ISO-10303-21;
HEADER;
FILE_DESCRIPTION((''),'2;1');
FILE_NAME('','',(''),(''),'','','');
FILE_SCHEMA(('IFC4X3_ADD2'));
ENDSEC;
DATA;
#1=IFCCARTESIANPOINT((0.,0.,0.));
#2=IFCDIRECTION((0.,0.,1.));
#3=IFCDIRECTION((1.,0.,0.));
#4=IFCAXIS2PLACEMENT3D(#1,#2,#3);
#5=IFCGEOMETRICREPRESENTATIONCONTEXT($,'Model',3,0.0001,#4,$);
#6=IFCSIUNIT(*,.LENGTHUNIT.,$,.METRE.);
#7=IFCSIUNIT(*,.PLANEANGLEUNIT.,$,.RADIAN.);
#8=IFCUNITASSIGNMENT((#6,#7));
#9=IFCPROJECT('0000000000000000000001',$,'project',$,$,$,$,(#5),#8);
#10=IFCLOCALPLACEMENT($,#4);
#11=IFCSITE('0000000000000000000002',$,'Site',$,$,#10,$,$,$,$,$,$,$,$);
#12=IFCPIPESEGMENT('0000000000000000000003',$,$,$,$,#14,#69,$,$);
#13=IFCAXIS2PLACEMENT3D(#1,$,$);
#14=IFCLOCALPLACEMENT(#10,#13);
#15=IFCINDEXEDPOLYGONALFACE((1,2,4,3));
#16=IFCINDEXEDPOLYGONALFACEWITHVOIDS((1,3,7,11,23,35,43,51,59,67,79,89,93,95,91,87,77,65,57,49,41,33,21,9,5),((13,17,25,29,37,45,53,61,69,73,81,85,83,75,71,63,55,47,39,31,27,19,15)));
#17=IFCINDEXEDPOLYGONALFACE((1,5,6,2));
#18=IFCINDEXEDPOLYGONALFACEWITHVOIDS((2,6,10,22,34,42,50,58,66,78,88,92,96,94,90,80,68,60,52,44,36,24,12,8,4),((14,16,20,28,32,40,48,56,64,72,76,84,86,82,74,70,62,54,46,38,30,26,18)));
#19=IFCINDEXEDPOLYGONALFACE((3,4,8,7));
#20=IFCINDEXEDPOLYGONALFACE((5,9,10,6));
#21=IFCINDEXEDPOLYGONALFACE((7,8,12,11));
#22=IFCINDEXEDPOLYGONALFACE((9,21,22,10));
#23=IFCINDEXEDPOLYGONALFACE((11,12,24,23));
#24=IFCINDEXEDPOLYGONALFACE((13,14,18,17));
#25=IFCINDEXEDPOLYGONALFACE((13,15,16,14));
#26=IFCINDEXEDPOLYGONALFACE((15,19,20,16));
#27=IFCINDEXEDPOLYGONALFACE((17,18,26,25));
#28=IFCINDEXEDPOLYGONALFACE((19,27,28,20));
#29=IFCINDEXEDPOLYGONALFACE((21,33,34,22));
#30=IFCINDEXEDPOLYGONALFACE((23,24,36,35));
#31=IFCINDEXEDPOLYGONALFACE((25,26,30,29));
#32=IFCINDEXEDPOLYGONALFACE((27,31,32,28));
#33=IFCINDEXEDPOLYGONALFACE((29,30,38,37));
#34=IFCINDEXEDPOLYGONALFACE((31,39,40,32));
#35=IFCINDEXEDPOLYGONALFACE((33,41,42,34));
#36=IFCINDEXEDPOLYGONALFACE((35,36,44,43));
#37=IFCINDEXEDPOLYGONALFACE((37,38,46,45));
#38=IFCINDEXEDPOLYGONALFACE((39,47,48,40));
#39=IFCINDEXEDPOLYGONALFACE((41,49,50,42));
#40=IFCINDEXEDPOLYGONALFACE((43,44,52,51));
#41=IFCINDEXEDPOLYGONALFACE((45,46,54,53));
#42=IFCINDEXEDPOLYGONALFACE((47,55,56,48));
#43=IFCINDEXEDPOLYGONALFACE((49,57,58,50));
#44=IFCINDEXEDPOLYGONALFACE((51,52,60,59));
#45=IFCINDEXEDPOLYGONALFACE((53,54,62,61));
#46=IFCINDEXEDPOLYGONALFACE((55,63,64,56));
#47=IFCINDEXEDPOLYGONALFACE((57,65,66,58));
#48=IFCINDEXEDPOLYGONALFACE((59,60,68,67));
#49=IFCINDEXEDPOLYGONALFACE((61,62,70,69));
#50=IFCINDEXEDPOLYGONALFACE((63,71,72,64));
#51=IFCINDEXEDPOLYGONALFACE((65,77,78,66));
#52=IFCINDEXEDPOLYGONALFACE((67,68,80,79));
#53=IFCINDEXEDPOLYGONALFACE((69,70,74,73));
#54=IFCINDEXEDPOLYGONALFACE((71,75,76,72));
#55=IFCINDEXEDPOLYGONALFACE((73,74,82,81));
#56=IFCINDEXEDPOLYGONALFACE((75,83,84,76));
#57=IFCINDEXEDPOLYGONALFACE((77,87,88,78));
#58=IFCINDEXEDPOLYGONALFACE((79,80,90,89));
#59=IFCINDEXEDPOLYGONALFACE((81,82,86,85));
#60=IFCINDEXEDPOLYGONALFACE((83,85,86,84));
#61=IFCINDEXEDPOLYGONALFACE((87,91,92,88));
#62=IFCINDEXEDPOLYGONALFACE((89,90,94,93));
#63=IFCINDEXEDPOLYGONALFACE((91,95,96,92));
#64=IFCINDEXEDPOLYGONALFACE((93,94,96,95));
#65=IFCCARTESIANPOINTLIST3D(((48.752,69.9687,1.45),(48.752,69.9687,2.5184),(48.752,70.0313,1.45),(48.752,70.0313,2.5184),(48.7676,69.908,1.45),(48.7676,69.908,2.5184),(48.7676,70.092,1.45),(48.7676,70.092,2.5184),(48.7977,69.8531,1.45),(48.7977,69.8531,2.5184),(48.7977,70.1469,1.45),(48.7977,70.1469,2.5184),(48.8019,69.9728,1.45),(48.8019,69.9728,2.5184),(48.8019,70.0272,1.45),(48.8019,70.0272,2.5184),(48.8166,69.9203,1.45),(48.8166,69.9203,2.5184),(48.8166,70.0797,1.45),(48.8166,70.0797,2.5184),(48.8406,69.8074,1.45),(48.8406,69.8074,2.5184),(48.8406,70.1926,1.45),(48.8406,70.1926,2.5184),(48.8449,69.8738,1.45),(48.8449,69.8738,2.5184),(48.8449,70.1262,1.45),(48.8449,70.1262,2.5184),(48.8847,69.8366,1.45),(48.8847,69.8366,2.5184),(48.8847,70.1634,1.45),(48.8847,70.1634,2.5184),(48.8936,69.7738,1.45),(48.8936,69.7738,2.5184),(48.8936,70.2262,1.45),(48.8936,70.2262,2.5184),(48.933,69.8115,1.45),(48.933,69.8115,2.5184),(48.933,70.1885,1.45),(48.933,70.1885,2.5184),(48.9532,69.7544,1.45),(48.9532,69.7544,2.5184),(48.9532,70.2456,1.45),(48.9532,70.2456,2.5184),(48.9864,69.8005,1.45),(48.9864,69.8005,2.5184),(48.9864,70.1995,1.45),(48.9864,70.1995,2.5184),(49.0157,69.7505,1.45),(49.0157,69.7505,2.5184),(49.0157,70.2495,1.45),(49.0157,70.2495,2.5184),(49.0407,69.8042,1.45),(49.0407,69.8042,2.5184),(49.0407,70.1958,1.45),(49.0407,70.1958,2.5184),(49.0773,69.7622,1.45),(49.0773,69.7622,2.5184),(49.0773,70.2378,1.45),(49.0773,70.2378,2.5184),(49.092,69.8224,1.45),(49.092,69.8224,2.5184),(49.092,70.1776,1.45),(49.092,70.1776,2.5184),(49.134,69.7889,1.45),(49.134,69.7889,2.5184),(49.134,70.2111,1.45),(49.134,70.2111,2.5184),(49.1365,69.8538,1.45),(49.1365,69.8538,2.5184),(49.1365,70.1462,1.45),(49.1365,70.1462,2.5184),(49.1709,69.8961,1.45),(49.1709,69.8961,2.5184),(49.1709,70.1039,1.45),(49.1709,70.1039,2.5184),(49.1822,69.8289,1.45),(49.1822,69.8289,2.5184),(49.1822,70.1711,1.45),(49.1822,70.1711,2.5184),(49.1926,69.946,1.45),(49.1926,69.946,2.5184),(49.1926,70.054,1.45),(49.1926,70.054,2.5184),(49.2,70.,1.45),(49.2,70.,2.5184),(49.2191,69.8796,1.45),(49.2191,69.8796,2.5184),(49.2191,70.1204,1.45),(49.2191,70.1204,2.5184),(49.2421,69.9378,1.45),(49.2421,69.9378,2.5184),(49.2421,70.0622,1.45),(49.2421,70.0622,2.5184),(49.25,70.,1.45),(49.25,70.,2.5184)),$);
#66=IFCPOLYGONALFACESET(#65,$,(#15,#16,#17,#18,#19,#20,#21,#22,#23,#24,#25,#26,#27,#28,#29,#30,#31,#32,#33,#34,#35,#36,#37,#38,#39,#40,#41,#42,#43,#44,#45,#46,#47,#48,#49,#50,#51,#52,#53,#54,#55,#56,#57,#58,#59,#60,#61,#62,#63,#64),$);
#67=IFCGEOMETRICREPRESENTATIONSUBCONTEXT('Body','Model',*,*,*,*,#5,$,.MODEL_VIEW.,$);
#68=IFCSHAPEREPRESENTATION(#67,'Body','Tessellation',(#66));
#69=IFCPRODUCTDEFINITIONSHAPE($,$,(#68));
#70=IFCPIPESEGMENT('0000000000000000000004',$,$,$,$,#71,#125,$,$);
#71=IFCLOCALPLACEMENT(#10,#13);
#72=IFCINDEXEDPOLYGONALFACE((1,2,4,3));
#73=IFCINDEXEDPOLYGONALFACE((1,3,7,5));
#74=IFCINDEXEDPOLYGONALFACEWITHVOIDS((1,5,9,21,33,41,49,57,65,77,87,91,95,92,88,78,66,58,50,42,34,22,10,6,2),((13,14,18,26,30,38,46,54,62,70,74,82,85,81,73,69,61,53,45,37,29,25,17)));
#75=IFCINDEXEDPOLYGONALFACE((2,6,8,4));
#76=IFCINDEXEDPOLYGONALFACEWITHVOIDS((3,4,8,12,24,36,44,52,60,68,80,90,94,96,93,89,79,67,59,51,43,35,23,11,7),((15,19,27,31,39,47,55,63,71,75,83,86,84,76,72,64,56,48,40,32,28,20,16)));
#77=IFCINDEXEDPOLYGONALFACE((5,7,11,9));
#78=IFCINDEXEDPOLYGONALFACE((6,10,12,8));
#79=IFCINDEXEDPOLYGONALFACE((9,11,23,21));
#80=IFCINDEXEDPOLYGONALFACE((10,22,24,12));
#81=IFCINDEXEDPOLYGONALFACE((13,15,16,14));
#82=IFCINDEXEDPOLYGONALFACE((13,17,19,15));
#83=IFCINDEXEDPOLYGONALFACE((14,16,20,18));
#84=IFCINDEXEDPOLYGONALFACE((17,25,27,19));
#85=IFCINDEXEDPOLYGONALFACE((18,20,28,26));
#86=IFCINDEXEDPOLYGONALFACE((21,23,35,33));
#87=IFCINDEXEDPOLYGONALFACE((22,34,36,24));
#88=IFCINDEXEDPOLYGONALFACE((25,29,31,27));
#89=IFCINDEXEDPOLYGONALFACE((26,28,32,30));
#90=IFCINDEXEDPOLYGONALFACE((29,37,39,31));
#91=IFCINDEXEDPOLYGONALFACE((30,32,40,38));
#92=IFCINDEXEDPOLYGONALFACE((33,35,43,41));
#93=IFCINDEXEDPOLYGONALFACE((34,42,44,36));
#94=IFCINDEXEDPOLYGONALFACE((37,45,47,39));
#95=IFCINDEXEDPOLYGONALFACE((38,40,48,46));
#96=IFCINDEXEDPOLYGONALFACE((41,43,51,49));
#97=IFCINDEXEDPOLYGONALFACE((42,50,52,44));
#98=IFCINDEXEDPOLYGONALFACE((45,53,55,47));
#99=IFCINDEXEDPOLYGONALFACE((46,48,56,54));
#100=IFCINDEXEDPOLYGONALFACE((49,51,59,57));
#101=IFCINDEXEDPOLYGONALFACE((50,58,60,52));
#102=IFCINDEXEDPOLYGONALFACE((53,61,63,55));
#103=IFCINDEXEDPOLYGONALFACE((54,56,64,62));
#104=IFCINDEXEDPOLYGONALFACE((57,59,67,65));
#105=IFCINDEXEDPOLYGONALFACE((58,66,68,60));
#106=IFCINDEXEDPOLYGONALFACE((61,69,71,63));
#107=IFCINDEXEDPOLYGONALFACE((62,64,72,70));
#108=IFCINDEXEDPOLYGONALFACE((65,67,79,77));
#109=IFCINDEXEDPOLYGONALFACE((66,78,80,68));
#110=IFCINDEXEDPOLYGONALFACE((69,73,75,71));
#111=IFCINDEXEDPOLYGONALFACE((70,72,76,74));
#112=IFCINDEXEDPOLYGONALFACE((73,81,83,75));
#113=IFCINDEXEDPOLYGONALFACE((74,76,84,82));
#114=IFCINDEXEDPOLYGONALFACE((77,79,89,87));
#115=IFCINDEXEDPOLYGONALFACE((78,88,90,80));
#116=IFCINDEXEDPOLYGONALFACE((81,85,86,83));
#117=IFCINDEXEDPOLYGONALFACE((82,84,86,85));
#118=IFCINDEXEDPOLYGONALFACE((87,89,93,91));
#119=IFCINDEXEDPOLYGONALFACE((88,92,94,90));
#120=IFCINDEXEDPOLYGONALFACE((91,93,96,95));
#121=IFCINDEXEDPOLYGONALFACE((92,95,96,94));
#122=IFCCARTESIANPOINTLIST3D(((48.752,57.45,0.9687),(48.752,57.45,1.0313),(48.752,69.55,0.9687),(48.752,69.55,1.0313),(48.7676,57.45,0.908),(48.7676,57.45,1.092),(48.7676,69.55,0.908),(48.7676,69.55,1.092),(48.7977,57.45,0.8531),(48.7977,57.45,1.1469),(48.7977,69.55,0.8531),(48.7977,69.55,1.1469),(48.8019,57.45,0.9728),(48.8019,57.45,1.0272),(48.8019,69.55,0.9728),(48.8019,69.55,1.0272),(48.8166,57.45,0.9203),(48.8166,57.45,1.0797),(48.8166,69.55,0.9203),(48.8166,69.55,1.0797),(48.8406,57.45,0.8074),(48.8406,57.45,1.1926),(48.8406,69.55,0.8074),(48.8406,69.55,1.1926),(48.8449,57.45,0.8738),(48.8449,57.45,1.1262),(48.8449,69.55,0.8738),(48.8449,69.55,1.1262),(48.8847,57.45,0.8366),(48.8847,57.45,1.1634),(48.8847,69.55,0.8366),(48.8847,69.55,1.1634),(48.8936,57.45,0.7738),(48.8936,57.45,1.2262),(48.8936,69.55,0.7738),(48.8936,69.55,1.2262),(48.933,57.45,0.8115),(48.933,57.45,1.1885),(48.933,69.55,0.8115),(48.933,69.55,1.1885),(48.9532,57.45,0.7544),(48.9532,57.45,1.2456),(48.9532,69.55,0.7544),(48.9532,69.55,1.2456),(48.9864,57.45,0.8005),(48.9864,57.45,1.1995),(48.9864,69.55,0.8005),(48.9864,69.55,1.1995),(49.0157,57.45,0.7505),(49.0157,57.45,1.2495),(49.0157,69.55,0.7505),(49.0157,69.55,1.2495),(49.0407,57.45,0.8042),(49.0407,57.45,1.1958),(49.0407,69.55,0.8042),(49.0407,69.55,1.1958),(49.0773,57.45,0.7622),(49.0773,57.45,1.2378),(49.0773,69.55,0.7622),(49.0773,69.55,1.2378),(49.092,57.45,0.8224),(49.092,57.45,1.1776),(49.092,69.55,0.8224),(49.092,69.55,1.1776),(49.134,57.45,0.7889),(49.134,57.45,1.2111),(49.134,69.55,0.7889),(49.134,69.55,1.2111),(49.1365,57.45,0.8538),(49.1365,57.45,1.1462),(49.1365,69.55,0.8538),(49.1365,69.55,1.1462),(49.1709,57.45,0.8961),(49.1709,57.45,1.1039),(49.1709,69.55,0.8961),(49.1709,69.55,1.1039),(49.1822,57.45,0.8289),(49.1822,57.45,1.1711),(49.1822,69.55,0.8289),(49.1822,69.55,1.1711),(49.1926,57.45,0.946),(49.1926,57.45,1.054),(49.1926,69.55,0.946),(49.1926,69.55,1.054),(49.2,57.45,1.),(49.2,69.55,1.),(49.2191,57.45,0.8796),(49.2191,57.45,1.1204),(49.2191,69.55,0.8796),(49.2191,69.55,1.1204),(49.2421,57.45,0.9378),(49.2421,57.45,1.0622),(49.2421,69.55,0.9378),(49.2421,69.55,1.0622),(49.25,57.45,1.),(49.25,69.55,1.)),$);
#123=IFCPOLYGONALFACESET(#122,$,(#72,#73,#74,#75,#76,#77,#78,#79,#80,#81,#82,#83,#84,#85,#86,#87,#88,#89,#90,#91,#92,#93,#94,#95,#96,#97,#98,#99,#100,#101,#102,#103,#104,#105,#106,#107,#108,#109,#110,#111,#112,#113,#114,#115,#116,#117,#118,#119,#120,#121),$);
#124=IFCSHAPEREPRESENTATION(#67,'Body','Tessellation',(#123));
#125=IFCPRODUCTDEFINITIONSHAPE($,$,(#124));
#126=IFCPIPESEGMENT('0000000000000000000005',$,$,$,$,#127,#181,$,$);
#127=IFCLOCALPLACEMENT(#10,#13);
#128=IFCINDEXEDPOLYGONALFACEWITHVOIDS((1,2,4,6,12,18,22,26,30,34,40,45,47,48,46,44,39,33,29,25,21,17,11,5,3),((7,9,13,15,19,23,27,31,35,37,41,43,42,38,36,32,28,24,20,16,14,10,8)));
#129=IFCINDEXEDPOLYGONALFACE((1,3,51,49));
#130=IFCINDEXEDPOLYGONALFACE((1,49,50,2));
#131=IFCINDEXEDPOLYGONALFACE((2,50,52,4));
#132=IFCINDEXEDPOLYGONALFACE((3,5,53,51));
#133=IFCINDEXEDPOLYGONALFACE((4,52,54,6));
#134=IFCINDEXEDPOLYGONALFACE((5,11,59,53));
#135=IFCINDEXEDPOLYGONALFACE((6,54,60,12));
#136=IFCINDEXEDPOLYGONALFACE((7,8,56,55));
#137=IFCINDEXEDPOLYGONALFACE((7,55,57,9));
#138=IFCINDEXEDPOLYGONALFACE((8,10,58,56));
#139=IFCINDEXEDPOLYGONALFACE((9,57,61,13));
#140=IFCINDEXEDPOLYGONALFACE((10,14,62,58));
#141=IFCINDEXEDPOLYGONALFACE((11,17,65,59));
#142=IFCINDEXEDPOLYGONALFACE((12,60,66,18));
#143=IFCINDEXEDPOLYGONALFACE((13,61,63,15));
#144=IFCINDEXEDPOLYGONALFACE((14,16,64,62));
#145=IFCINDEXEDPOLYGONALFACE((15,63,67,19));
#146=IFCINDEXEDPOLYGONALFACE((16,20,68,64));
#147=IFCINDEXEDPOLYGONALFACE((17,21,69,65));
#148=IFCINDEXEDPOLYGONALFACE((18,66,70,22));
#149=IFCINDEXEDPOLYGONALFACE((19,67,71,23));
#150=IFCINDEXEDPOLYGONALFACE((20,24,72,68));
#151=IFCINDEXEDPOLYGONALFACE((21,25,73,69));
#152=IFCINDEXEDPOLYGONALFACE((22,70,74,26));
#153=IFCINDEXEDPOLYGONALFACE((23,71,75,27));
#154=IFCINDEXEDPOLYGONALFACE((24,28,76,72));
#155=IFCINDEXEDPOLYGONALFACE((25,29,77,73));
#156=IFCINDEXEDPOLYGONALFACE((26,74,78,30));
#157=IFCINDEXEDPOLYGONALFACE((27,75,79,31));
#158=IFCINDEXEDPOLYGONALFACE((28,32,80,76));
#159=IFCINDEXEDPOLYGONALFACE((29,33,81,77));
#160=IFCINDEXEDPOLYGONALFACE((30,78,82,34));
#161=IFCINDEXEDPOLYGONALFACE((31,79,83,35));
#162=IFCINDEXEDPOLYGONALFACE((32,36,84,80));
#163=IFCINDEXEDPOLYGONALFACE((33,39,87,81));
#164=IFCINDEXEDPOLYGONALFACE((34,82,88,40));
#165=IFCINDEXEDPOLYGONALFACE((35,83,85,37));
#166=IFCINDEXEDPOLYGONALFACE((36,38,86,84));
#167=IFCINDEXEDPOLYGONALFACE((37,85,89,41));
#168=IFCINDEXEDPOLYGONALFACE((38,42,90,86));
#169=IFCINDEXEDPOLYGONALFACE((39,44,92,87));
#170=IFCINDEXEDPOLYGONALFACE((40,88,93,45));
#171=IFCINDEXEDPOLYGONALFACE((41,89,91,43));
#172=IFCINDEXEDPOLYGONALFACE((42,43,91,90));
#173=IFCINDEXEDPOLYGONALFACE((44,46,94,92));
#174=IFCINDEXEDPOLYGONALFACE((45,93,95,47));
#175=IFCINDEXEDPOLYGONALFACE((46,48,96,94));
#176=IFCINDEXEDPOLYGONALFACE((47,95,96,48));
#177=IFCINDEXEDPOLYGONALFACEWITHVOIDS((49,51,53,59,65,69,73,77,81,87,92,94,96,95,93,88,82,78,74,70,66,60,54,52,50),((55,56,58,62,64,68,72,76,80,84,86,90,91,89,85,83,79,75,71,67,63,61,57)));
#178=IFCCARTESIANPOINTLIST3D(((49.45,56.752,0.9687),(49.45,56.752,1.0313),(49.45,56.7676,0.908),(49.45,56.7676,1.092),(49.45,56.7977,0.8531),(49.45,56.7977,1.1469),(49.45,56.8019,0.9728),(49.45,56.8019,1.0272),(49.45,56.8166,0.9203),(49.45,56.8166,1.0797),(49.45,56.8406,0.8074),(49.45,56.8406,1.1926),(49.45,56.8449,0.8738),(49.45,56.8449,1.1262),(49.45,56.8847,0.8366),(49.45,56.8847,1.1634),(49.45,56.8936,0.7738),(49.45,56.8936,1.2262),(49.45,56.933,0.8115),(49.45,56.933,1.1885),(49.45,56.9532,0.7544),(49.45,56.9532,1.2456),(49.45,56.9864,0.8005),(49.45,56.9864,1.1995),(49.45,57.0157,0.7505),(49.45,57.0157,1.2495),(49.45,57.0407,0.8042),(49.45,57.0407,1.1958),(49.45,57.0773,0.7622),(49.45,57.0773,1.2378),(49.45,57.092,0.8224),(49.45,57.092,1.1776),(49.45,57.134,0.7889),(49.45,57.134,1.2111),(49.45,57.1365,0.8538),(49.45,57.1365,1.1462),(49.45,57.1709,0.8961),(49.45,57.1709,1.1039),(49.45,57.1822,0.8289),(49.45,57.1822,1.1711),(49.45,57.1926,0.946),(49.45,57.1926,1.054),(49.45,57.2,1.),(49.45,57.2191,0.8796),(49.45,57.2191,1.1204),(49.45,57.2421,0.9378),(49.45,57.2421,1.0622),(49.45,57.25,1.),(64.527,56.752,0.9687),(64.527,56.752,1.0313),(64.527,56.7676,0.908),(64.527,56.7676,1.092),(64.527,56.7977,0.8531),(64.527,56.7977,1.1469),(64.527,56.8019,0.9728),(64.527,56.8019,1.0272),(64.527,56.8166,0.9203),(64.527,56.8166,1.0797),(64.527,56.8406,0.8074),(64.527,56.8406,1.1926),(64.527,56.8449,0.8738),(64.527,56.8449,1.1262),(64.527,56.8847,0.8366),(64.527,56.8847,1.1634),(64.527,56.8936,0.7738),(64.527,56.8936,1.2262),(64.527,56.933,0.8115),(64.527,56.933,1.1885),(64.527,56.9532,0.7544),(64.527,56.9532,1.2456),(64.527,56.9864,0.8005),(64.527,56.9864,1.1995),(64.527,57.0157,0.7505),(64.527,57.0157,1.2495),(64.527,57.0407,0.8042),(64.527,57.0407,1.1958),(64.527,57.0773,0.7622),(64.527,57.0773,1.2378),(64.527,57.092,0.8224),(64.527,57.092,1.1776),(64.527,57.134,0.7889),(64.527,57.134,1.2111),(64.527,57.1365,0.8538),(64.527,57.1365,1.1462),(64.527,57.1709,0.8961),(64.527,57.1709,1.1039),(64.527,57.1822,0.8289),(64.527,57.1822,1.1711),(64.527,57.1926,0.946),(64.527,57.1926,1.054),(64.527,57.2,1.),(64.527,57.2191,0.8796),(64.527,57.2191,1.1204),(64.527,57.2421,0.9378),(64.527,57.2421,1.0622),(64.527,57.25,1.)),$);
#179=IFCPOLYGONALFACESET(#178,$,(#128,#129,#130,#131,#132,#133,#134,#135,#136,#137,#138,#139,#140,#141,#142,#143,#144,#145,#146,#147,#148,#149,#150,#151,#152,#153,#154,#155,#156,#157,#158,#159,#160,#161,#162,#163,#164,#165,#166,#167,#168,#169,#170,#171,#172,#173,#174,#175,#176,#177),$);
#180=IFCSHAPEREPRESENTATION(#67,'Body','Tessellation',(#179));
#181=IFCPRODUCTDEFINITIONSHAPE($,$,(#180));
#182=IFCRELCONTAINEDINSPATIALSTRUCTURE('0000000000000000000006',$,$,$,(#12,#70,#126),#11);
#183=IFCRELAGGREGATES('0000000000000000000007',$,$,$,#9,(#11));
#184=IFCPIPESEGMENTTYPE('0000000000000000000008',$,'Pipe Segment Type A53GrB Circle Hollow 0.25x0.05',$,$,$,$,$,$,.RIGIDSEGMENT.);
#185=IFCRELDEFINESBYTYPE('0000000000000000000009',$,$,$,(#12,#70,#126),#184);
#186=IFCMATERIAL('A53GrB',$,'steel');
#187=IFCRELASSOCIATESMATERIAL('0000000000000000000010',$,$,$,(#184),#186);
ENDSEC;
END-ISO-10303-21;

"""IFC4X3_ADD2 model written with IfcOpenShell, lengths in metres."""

from ifc_helpers import new_model, si_unit, frame, origin_with_axes, place, context, subcontext, project, spatial, hollow_circle, extrude, material, material_profile, profile_set, type_object, element, save


model = new_model("IFC4X3_ADD2")

# Units and contexts
model_context = context("Model", 3, precision=0.0001, world=origin_with_axes())
body_context = subcontext(model_context, "Body", "Model", "MODEL_VIEW")
ifc_project = project(units=[si_unit("LENGTHUNIT", "METRE"), si_unit("PLANEANGLEUNIT", "RADIAN")], contexts=[model_context])

# Site
site_placement = place(None, origin_with_axes())
site = spatial("IfcSite", under=ifc_project, at=site_placement, Name="Site")

# Pipe segments
ifc_material = material(Name="A53GrB", Category="steel")
ifc_material_profile = material_profile(ifc_material, hollow_circle(Radius=0.25, WallThickness=0.05))
ifc_profile_set = profile_set([ifc_material_profile], Name="A53GrB steel Circle Hollow 0.25x0.05")
pipe_segment_type = type_object("IfcPipeSegmentType", Name="Pipe Segment Type A53GrB Circle Hollow 0.25x0.05", PredefinedType="RIGIDSEGMENT", material=ifc_profile_set)
pipe_segment_1_placement = place(None, frame((49.0, 70.0, 2.5184), z_axis=(0.0, 0.0, -1.0), x_axis=(1.0, 0.0, 0.0)))
element("IfcPipeSegment", 1, at=pipe_segment_1_placement, inside=site, type_object=pipe_segment_type, context=body_context, shape_type="SweptSolid", body=[
    extrude(hollow_circle(Radius=0.25, WallThickness=0.05), origin_with_axes(), (0.0, 0.0, 1.0), 1.0684),
])
pipe_segment_2_placement = place(None, frame((49.0, 69.55, 1.0), z_axis=(0.0, -1.0, 0.0), x_axis=(1.0, 0.0, 0.0)))
element("IfcPipeSegment", 2, at=pipe_segment_2_placement, inside=site, type_object=pipe_segment_type, context=body_context, shape_type="SweptSolid", body=[
    extrude(hollow_circle(Radius=0.25, WallThickness=0.05), origin_with_axes(), (0.0, 0.0, 1.0), 12.1),
])
pipe_segment_3_placement = place(None, frame((49.45, 57.0, 1.0), z_axis=(1.0, 0.0, 0.0), x_axis=(0.0, 1.0, 0.0)))
element("IfcPipeSegment", 3, at=pipe_segment_3_placement, inside=site, type_object=pipe_segment_type, context=body_context, shape_type="SweptSolid", body=[
    extrude(hollow_circle(Radius=0.25, WallThickness=0.05), origin_with_axes(), (0.0, 0.0, 1.0), 15.077),
])

save(model, "model.ifc")
